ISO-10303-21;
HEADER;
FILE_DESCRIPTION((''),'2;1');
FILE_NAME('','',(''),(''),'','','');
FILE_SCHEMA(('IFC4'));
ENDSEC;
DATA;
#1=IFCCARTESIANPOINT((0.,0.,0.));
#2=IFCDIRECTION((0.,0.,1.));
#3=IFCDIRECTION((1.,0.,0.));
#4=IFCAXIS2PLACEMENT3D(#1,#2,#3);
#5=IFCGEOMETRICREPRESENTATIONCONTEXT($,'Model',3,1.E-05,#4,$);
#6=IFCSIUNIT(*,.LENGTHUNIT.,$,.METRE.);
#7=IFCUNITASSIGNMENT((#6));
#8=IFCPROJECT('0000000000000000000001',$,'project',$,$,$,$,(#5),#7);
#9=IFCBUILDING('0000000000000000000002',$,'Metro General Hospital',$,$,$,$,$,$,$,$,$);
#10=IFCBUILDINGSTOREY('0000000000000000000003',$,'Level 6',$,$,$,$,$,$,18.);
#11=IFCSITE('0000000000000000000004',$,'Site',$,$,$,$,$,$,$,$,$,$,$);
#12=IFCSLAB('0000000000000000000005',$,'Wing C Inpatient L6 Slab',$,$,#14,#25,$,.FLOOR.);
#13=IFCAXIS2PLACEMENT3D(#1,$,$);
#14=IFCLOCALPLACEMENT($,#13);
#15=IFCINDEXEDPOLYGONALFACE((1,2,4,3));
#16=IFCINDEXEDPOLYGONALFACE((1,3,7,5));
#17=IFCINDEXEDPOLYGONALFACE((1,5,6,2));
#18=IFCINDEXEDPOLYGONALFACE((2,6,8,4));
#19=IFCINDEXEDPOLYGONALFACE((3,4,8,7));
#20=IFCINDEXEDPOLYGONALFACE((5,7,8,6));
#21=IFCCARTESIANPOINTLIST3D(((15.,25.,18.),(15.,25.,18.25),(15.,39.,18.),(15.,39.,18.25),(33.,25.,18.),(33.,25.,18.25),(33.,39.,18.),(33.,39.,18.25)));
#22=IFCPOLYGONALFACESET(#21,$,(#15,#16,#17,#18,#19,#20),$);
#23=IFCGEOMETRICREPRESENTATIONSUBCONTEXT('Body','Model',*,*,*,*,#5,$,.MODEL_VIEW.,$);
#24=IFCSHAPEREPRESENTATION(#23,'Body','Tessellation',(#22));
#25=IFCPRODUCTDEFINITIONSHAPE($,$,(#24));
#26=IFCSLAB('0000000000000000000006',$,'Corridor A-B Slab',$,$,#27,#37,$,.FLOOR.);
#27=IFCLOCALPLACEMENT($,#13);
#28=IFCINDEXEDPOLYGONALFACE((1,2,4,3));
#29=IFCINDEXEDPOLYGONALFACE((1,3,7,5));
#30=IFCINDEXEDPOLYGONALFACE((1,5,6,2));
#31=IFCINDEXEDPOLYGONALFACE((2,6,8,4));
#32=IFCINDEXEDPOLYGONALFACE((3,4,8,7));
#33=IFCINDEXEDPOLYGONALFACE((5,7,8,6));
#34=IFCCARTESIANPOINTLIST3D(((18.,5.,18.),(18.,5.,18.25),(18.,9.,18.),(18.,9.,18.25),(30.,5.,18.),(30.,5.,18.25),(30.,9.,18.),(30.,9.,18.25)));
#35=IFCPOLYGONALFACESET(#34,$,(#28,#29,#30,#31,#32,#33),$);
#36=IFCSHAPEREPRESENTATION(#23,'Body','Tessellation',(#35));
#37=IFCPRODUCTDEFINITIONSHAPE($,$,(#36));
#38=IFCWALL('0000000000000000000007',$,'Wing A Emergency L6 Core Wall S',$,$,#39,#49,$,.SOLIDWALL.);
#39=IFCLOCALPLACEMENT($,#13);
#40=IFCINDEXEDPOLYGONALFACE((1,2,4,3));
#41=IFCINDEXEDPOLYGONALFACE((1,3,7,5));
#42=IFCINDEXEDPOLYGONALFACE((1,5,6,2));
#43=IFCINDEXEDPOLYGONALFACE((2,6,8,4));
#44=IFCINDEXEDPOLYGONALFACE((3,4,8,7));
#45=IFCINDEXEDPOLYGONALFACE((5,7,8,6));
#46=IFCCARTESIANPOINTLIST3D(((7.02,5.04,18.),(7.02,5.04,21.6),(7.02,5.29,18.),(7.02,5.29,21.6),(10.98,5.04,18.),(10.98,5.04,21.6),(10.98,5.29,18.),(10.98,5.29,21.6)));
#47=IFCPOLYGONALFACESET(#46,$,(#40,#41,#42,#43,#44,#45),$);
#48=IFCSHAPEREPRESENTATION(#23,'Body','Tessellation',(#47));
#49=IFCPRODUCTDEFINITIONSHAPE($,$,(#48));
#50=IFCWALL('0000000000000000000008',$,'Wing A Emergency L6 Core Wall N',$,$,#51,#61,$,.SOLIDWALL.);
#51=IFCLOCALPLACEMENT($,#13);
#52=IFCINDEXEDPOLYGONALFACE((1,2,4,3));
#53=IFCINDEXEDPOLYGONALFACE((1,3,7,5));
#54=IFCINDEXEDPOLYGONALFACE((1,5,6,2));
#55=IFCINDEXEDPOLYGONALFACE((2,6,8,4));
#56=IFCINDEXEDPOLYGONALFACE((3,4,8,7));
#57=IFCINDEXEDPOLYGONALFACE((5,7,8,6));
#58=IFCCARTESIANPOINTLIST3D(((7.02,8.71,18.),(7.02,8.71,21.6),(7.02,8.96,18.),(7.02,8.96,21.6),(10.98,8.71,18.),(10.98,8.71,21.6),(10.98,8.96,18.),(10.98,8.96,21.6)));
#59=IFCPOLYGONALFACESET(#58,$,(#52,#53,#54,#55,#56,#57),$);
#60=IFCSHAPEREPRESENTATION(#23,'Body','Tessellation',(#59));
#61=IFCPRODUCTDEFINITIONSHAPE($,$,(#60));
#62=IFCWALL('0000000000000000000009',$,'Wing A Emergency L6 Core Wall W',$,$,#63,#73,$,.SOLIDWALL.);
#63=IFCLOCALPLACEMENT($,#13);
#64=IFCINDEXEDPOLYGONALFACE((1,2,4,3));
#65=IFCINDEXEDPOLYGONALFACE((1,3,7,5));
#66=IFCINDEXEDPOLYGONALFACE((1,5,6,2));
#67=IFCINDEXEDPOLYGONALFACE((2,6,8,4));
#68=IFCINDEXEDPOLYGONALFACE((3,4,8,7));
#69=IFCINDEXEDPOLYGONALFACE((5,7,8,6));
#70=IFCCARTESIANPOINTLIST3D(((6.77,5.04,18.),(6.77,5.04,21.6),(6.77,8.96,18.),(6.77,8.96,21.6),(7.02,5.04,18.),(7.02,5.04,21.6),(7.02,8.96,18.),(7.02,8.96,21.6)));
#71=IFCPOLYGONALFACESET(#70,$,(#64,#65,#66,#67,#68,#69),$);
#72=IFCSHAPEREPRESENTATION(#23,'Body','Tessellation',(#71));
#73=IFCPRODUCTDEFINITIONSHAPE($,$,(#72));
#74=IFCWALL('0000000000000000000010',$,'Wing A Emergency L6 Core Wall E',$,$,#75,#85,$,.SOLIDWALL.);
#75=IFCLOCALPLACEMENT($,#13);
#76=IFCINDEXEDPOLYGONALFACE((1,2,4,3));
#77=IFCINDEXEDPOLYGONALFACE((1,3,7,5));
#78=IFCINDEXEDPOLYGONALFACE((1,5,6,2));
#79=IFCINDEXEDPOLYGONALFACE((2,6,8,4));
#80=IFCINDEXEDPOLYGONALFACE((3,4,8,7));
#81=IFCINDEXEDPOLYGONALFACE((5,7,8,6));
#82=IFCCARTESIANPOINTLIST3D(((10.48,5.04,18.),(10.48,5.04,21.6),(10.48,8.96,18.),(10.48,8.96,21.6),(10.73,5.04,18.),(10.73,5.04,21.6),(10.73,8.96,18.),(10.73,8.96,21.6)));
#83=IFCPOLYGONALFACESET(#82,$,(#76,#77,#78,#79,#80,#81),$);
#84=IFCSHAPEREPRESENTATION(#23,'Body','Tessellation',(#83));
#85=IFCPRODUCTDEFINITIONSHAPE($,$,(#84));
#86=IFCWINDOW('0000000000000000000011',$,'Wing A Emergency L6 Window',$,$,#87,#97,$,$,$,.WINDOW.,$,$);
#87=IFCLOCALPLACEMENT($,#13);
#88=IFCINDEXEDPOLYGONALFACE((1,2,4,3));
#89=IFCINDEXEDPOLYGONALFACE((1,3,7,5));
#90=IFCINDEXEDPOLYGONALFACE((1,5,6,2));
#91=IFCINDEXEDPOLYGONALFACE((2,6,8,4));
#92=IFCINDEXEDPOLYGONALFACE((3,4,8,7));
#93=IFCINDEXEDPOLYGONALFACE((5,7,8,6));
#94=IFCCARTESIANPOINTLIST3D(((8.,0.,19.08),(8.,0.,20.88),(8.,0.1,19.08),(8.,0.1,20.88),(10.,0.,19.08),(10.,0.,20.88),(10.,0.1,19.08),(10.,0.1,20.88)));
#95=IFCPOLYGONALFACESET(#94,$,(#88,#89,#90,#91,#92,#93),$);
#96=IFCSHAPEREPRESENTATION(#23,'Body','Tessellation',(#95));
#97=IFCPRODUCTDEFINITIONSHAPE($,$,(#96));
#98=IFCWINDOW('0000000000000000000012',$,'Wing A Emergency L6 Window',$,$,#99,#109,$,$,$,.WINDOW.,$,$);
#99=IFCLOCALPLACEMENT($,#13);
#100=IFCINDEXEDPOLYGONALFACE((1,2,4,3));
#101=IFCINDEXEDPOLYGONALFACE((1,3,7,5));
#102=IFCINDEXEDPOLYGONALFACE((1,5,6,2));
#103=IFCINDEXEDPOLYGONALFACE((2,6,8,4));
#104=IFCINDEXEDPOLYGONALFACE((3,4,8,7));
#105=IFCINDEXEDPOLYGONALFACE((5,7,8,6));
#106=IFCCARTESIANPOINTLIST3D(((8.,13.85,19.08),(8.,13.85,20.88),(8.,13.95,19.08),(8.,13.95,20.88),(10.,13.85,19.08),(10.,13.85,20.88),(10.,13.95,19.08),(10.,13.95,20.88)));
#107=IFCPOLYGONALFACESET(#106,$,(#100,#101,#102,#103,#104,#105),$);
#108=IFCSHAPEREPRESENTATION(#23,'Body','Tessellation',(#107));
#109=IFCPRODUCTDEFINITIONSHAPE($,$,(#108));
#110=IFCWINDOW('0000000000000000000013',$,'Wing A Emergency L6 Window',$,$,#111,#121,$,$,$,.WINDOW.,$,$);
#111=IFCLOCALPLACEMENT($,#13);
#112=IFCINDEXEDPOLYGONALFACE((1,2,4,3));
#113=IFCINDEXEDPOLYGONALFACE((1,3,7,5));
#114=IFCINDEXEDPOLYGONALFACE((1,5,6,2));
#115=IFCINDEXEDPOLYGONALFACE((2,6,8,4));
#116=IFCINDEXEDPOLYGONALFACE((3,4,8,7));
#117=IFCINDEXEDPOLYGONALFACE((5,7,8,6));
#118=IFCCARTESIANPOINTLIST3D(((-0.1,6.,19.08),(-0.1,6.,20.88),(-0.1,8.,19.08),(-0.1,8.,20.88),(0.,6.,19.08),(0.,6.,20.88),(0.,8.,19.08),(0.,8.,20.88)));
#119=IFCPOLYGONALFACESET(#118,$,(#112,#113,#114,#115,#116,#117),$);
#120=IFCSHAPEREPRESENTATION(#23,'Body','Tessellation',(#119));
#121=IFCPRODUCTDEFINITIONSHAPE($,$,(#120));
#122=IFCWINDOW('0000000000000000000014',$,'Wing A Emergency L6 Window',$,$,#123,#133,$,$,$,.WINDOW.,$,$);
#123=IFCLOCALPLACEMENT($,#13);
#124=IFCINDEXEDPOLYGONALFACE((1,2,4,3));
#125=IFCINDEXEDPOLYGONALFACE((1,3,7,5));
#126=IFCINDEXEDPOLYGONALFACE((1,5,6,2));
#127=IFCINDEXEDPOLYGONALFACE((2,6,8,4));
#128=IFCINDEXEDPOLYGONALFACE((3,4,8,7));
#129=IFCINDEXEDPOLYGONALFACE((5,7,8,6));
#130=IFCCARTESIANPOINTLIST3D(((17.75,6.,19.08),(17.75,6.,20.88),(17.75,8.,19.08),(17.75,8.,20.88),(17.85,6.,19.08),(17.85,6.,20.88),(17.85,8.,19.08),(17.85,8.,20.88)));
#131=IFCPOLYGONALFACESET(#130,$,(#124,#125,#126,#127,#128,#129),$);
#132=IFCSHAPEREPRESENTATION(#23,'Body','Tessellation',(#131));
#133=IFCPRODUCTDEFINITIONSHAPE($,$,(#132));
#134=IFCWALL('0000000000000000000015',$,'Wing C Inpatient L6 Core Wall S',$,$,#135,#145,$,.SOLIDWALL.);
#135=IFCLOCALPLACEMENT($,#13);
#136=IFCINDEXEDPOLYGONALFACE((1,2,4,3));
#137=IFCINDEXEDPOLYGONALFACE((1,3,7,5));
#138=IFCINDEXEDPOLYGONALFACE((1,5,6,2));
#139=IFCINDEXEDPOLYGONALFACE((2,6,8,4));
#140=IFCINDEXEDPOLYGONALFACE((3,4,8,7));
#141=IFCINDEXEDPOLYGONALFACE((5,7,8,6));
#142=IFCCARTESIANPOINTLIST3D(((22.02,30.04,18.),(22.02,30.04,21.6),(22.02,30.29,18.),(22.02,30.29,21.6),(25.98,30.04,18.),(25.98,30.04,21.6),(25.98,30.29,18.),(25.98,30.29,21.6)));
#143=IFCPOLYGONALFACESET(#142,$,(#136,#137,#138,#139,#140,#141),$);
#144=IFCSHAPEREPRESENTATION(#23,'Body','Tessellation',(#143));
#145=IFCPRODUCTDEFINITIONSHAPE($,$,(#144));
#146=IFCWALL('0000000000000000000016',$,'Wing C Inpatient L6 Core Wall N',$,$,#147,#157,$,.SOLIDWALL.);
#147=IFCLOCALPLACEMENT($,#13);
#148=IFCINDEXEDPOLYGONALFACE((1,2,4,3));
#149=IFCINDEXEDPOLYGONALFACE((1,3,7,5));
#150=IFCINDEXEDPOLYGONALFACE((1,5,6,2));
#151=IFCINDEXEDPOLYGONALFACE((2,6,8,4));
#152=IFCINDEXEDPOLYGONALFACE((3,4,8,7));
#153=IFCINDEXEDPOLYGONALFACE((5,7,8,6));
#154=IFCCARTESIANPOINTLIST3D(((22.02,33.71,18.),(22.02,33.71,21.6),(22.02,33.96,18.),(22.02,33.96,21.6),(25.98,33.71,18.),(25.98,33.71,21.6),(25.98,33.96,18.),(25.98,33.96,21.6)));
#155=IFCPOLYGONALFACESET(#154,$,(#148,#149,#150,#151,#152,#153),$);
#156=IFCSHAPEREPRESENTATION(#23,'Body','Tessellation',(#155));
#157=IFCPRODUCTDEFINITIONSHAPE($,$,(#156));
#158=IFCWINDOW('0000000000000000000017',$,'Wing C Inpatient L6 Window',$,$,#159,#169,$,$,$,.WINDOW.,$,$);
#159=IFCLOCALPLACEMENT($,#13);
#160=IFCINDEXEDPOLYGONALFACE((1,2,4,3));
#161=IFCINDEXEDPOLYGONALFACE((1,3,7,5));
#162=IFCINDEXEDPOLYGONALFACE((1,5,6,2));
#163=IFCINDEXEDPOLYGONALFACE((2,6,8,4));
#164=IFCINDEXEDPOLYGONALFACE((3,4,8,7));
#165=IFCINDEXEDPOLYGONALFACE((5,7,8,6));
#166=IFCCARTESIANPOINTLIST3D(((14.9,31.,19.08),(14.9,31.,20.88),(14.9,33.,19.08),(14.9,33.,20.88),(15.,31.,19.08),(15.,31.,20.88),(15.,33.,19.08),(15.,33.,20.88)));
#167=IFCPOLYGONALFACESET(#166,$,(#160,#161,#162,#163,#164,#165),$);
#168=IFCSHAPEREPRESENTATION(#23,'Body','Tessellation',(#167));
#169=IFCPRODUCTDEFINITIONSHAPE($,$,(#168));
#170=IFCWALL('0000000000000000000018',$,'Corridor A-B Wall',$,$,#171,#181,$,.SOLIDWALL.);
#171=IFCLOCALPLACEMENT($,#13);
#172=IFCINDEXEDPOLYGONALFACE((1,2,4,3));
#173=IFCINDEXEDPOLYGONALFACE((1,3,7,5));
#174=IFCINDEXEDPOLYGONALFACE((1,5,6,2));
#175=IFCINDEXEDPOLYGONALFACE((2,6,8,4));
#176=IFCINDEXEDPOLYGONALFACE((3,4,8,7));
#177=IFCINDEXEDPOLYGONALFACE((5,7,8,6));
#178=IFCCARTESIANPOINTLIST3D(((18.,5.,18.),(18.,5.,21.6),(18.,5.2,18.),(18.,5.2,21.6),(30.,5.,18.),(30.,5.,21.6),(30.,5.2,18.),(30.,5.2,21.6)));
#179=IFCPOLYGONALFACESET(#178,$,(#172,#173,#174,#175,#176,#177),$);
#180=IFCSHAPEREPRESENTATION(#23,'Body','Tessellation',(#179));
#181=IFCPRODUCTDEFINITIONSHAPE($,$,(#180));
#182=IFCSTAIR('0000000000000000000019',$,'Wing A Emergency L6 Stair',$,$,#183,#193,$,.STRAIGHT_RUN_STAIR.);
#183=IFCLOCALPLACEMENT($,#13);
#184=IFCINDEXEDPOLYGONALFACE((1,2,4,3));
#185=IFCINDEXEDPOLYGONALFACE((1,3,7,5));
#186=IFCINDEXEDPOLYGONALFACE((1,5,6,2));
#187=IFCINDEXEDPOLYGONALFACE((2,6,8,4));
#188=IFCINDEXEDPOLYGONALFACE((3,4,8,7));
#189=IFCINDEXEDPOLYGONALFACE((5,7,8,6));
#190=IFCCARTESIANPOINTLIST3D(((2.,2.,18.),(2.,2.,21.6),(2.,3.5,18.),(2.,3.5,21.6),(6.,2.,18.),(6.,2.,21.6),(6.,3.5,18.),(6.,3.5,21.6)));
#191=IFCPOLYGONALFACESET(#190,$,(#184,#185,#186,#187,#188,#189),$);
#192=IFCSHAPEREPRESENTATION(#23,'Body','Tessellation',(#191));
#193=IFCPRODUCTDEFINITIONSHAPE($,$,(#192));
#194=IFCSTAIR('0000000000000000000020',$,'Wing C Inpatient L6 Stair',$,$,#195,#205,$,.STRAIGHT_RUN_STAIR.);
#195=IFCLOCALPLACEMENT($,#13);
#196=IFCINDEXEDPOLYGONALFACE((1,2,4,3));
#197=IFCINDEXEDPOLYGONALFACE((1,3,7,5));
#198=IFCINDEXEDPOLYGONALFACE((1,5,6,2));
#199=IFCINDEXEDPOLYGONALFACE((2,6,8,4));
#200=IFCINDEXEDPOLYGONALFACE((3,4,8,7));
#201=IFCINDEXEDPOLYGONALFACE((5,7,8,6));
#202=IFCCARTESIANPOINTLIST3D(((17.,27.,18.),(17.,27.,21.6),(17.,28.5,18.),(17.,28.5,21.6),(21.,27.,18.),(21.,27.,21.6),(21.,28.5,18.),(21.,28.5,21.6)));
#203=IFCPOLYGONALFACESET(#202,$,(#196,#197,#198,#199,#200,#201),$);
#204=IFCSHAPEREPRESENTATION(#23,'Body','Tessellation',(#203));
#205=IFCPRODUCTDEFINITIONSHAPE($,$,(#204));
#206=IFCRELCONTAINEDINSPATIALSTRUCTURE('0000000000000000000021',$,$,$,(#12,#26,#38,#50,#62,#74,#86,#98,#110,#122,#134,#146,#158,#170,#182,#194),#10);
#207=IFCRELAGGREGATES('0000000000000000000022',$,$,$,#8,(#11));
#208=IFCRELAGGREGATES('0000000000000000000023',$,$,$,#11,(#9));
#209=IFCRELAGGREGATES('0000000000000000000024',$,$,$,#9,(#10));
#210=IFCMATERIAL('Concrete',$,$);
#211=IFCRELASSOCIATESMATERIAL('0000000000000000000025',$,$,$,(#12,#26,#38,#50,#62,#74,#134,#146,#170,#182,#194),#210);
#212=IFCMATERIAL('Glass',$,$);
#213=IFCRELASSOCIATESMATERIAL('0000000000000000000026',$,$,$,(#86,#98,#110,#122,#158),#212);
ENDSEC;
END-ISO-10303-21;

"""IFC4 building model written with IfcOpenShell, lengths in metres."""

from ifc_helpers import new_model, si_unit, frame, origin_with_axes, place, context, subcontext, project, spatial, line, indexed_curve, outline, extrude, material, element, save


model = new_model("IFC4")

# Units and contexts
model_context = context("Model", 3, precision=1e-05, world=origin_with_axes())
body_context = subcontext(model_context, "Body", "Model", "MODEL_VIEW")
ifc_project = project(units=[si_unit("LENGTHUNIT", "METRE")], contexts=[model_context])

# Site, building, storey
site = spatial("IfcSite", under=ifc_project, Name="Site")
building = spatial("IfcBuilding", under=site, Name="Metro General Hospital")
storey = spatial("IfcBuildingStorey", under=building, Name="Level 6", Elevation=18.0)

# Slabs
ifc_material_1 = material(Name="Concrete")
for number, where, z_axis, x_axis, name in (
    (1, (15.0, 25.0, 18.0), (0.0, 0.0, 1.0), (1.0, 0.0, 0.0), "Wing C Inpatient L6 Slab"),
):
    element("IfcSlab", number, at=place(None, frame(where, z_axis=z_axis, x_axis=x_axis)), inside=storey, material=ifc_material_1, Name=name, PredefinedType="FLOOR", context=body_context, shape_type="SweptSolid", body=[
        extrude(outline(indexed_curve([(0.0, 0.0), (18.0, 0.0), (18.0, 14.0), (0.0, 14.0)], segments=[line(1, 2, 3, 4, 1)])), origin_with_axes(), (0.0, 0.0, 1.0), 0.25),
    ])
slab_placement = place(None, frame((18.0, 5.0, 18.0), z_axis=(0.0, 0.0, 1.0), x_axis=(1.0, 0.0, 0.0)))
element("IfcSlab", 2, at=slab_placement, inside=storey, material=ifc_material_1, Name="Corridor A-B Slab", PredefinedType="FLOOR", context=body_context, shape_type="SweptSolid", body=[
    extrude(outline(indexed_curve([(0.0, 0.0), (12.0, 0.0), (12.0, 4.0), (0.0, 4.0)], segments=[line(1, 2, 3, 4, 1)])), origin_with_axes(), (0.0, 0.0, 1.0), 0.25),
])

# Walls
for number, where, z_axis, x_axis, name in (
    (3, (7.02, 5.04, 18.0), (0.0, 0.0, 1.0), (1.0, 0.0, 0.0), "Wing A Emergency L6 Core Wall S"),
    (4, (7.02, 8.71, 18.0), (0.0, 0.0, 1.0), (1.0, 0.0, 0.0), "Wing A Emergency L6 Core Wall N"),
):
    element("IfcWall", number, at=place(None, frame(where, z_axis=z_axis, x_axis=x_axis)), inside=storey, material=ifc_material_1, Name=name, PredefinedType="SOLIDWALL", context=body_context, shape_type="SweptSolid", body=[
        extrude(outline(indexed_curve([(0.0, 0.0), (3.96, 0.0), (3.96, 0.25), (0.0, 0.25)], segments=[line(1, 2, 3, 4, 1)])), origin_with_axes(), (0.0, 0.0, 1.0), 3.6),
    ])
for number, where, z_axis, x_axis, name in (
    (5, (7.02, 5.04, 18.0), (0.0, 0.0, 1.0), (0.0, 1.0, 0.0), "Wing A Emergency L6 Core Wall W"),
    (6, (10.73, 5.04, 18.0), (0.0, 0.0, 1.0), (0.0, 1.0, 0.0), "Wing A Emergency L6 Core Wall E"),
):
    element("IfcWall", number, at=place(None, frame(where, z_axis=z_axis, x_axis=x_axis)), inside=storey, material=ifc_material_1, Name=name, PredefinedType="SOLIDWALL", context=body_context, shape_type="SweptSolid", body=[
        extrude(outline(indexed_curve([(0.0, 0.0), (3.92, 0.0), (3.92, 0.25), (0.0, 0.25)], segments=[line(1, 2, 3, 4, 1)])), origin_with_axes(), (0.0, 0.0, 1.0), 3.6),
    ])

# Windows
ifc_material_2 = material(Name="Glass")
for number, where, z_axis, x_axis, name in (
    (7, (8.0, 0.0, 19.08), (0.0, 0.0, 1.0), (1.0, 0.0, 0.0), "Wing A Emergency L6 Window"),
    (8, (8.0, 13.85, 19.08), (0.0, 0.0, 1.0), (1.0, 0.0, 0.0), "Wing A Emergency L6 Window"),
    (9, (0.0, 6.0, 19.08), (0.0, 0.0, 1.0), (0.0, 1.0, 0.0), "Wing A Emergency L6 Window"),
    (10, (17.85, 6.0, 19.08), (0.0, 0.0, 1.0), (0.0, 1.0, 0.0), "Wing A Emergency L6 Window"),
):
    element("IfcWindow", number, at=place(None, frame(where, z_axis=z_axis, x_axis=x_axis)), inside=storey, material=ifc_material_2, Name=name, PredefinedType="WINDOW", context=body_context, shape_type="SweptSolid", body=[
        extrude(outline(indexed_curve([(0.0, 0.0), (2.0, 0.0), (2.0, 0.1), (0.0, 0.1)], segments=[line(1, 2, 3, 4, 1)])), origin_with_axes(), (0.0, 0.0, 1.0), 1.8),
    ])

# Walls
for number, where, z_axis, x_axis, name in (
    (11, (22.02, 30.04, 18.0), (0.0, 0.0, 1.0), (1.0, 0.0, 0.0), "Wing C Inpatient L6 Core Wall S"),
    (12, (22.02, 33.71, 18.0), (0.0, 0.0, 1.0), (1.0, 0.0, 0.0), "Wing C Inpatient L6 Core Wall N"),
):
    element("IfcWall", number, at=place(None, frame(where, z_axis=z_axis, x_axis=x_axis)), inside=storey, material=ifc_material_1, Name=name, PredefinedType="SOLIDWALL", context=body_context, shape_type="SweptSolid", body=[
        extrude(outline(indexed_curve([(0.0, 0.0), (3.96, 0.0), (3.96, 0.25), (0.0, 0.25)], segments=[line(1, 2, 3, 4, 1)])), origin_with_axes(), (0.0, 0.0, 1.0), 3.6),
    ])

# Window
window_placement = place(None, frame((15.0, 31.0, 19.08), z_axis=(0.0, 0.0, 1.0), x_axis=(0.0, 1.0, 0.0)))
element("IfcWindow", 13, at=window_placement, inside=storey, material=ifc_material_2, Name="Wing C Inpatient L6 Window", PredefinedType="WINDOW", context=body_context, shape_type="SweptSolid", body=[
    extrude(outline(indexed_curve([(0.0, 0.0), (2.0, 0.0), (2.0, 0.1), (0.0, 0.1)], segments=[line(1, 2, 3, 4, 1)])), origin_with_axes(), (0.0, 0.0, 1.0), 1.8),
])

# Wall
wall_placement = place(None, frame((18.0, 5.0, 18.0), z_axis=(0.0, 0.0, 1.0), x_axis=(1.0, 0.0, 0.0)))
element("IfcWall", 14, at=wall_placement, inside=storey, material=ifc_material_1, Name="Corridor A-B Wall", PredefinedType="SOLIDWALL", context=body_context, shape_type="SweptSolid", body=[
    extrude(outline(indexed_curve([(0.0, 0.0), (12.0, 0.0), (12.0, 0.2), (0.0, 0.2)], segments=[line(1, 2, 3, 4, 1)])), origin_with_axes(), (0.0, 0.0, 1.0), 3.6),
])

# Stairs
for number, where, z_axis, x_axis, name in (
    (15, (2.0, 2.0, 18.0), (0.0, 0.0, 1.0), (1.0, 0.0, 0.0), "Wing A Emergency L6 Stair"),
    (16, (17.0, 27.0, 18.0), (0.0, 0.0, 1.0), (1.0, 0.0, 0.0), "Wing C Inpatient L6 Stair"),
):
    element("IfcStair", number, at=place(None, frame(where, z_axis=z_axis, x_axis=x_axis)), inside=storey, material=ifc_material_1, Name=name, PredefinedType="STRAIGHT_RUN_STAIR", context=body_context, shape_type="SweptSolid", body=[
        extrude(outline(indexed_curve([(0.0, 0.0), (4.0, 0.0), (4.0, 1.5), (0.0, 1.5)], segments=[line(1, 2, 3, 4, 1)])), origin_with_axes(), (0.0, 0.0, 1.0), 3.6),
    ])

save(model, "model.ifc")
